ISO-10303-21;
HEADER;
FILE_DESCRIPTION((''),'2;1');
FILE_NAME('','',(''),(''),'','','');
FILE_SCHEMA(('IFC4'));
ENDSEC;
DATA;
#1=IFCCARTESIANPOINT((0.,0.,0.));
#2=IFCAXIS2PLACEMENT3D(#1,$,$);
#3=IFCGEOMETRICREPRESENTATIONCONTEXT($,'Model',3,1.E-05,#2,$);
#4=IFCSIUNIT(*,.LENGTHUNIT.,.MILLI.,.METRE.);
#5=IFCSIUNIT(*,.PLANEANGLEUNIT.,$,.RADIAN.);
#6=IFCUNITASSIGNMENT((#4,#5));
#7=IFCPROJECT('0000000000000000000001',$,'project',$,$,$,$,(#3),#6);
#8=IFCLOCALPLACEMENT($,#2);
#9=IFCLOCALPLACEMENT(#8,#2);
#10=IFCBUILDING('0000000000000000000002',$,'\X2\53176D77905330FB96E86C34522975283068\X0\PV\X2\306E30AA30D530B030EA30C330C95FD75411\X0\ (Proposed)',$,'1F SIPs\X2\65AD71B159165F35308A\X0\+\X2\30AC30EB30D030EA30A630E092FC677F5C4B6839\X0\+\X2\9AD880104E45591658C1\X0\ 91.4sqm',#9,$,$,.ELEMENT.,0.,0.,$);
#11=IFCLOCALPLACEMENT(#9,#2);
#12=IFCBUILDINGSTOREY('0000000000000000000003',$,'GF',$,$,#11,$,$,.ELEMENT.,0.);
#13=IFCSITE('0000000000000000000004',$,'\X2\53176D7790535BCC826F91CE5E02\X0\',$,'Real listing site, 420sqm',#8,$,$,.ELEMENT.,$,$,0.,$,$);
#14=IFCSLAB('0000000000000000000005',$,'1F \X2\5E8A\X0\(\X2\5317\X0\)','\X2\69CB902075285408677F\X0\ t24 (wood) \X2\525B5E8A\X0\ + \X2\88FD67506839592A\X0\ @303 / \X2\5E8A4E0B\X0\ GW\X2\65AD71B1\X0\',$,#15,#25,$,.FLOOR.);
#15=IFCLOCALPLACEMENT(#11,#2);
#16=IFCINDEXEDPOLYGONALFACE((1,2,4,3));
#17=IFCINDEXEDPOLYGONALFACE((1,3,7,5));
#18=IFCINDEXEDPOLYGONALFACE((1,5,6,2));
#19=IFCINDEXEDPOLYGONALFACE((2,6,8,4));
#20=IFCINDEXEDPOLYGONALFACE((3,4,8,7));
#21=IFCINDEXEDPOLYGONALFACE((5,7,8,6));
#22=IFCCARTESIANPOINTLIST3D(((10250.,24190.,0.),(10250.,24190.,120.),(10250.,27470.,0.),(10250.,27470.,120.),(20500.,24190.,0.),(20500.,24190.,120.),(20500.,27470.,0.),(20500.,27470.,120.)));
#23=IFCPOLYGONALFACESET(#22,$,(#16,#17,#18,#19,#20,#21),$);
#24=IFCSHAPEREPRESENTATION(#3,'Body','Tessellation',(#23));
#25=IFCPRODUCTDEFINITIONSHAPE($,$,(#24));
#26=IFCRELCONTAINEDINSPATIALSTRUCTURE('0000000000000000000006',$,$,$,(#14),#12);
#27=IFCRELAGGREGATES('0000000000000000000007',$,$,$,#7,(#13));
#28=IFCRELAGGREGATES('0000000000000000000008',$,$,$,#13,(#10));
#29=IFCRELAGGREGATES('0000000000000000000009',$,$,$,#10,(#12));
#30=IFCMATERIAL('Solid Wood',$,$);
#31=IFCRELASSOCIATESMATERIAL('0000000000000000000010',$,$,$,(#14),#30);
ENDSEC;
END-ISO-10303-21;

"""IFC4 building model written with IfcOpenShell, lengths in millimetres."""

from ifc_helpers import new_model, si_unit, frame, frame_2d, origin, place, context, project, spatial, rectangle, extrude, material, element, save


model = new_model("IFC4")

# Units and contexts
model_context = context("Model", 3, precision=1e-05, world=origin())
ifc_project = project(units=[si_unit("LENGTHUNIT", "METRE", prefix="MILLI"), si_unit("PLANEANGLEUNIT", "RADIAN")], contexts=[model_context])

# Site, building, storey
site_placement = place(None, origin())
site = spatial("IfcSite", under=ifc_project, at=site_placement, Name="北海道富良野市", ObjectType="Real listing site, 420sqm", CompositionType="ELEMENT", RefElevation=0.0)
building_placement = place(site_placement, origin())
building = spatial("IfcBuilding", under=site, at=building_placement, Name="北海道・雨水利用とPVのオフグリッド志向 (Proposed)", ObjectType="1F SIPs断熱外張り+ガルバリウム鋼板屋根+高耐久外壁 91.4sqm", CompositionType="ELEMENT", ElevationOfRefHeight=0.0, ElevationOfTerrain=0.0)
storey_placement = place(building_placement, origin())
storey = spatial("IfcBuildingStorey", under=building, at=storey_placement, Name="GF", CompositionType="ELEMENT", Elevation=0.0)

# Shared definitions
ifc_material_1 = material(Name="Solid Wood")

# Slab
slab_placement = place(storey_placement, frame((5125.0, 12095.0, 0.0)))
element("IfcSlab", 1, at=slab_placement, inside=storey, material=ifc_material_1, Name="1F 床(北)", Description="構造用合板 t24 (wood) 剛床 + 製材根太 @303 / 床下 GW断熱", PredefinedType="FLOOR", context=model_context, shape_type="SweptSolid", body=[
    extrude(rectangle(XDim=10250.0, YDim=3280.0, at=frame_2d((5125.0, 1640.0))), frame((5125.0, 12095.0, 0.0)), (0.0, 0.0, 1.0), 120.0),
])

save(model, "model.ifc")
